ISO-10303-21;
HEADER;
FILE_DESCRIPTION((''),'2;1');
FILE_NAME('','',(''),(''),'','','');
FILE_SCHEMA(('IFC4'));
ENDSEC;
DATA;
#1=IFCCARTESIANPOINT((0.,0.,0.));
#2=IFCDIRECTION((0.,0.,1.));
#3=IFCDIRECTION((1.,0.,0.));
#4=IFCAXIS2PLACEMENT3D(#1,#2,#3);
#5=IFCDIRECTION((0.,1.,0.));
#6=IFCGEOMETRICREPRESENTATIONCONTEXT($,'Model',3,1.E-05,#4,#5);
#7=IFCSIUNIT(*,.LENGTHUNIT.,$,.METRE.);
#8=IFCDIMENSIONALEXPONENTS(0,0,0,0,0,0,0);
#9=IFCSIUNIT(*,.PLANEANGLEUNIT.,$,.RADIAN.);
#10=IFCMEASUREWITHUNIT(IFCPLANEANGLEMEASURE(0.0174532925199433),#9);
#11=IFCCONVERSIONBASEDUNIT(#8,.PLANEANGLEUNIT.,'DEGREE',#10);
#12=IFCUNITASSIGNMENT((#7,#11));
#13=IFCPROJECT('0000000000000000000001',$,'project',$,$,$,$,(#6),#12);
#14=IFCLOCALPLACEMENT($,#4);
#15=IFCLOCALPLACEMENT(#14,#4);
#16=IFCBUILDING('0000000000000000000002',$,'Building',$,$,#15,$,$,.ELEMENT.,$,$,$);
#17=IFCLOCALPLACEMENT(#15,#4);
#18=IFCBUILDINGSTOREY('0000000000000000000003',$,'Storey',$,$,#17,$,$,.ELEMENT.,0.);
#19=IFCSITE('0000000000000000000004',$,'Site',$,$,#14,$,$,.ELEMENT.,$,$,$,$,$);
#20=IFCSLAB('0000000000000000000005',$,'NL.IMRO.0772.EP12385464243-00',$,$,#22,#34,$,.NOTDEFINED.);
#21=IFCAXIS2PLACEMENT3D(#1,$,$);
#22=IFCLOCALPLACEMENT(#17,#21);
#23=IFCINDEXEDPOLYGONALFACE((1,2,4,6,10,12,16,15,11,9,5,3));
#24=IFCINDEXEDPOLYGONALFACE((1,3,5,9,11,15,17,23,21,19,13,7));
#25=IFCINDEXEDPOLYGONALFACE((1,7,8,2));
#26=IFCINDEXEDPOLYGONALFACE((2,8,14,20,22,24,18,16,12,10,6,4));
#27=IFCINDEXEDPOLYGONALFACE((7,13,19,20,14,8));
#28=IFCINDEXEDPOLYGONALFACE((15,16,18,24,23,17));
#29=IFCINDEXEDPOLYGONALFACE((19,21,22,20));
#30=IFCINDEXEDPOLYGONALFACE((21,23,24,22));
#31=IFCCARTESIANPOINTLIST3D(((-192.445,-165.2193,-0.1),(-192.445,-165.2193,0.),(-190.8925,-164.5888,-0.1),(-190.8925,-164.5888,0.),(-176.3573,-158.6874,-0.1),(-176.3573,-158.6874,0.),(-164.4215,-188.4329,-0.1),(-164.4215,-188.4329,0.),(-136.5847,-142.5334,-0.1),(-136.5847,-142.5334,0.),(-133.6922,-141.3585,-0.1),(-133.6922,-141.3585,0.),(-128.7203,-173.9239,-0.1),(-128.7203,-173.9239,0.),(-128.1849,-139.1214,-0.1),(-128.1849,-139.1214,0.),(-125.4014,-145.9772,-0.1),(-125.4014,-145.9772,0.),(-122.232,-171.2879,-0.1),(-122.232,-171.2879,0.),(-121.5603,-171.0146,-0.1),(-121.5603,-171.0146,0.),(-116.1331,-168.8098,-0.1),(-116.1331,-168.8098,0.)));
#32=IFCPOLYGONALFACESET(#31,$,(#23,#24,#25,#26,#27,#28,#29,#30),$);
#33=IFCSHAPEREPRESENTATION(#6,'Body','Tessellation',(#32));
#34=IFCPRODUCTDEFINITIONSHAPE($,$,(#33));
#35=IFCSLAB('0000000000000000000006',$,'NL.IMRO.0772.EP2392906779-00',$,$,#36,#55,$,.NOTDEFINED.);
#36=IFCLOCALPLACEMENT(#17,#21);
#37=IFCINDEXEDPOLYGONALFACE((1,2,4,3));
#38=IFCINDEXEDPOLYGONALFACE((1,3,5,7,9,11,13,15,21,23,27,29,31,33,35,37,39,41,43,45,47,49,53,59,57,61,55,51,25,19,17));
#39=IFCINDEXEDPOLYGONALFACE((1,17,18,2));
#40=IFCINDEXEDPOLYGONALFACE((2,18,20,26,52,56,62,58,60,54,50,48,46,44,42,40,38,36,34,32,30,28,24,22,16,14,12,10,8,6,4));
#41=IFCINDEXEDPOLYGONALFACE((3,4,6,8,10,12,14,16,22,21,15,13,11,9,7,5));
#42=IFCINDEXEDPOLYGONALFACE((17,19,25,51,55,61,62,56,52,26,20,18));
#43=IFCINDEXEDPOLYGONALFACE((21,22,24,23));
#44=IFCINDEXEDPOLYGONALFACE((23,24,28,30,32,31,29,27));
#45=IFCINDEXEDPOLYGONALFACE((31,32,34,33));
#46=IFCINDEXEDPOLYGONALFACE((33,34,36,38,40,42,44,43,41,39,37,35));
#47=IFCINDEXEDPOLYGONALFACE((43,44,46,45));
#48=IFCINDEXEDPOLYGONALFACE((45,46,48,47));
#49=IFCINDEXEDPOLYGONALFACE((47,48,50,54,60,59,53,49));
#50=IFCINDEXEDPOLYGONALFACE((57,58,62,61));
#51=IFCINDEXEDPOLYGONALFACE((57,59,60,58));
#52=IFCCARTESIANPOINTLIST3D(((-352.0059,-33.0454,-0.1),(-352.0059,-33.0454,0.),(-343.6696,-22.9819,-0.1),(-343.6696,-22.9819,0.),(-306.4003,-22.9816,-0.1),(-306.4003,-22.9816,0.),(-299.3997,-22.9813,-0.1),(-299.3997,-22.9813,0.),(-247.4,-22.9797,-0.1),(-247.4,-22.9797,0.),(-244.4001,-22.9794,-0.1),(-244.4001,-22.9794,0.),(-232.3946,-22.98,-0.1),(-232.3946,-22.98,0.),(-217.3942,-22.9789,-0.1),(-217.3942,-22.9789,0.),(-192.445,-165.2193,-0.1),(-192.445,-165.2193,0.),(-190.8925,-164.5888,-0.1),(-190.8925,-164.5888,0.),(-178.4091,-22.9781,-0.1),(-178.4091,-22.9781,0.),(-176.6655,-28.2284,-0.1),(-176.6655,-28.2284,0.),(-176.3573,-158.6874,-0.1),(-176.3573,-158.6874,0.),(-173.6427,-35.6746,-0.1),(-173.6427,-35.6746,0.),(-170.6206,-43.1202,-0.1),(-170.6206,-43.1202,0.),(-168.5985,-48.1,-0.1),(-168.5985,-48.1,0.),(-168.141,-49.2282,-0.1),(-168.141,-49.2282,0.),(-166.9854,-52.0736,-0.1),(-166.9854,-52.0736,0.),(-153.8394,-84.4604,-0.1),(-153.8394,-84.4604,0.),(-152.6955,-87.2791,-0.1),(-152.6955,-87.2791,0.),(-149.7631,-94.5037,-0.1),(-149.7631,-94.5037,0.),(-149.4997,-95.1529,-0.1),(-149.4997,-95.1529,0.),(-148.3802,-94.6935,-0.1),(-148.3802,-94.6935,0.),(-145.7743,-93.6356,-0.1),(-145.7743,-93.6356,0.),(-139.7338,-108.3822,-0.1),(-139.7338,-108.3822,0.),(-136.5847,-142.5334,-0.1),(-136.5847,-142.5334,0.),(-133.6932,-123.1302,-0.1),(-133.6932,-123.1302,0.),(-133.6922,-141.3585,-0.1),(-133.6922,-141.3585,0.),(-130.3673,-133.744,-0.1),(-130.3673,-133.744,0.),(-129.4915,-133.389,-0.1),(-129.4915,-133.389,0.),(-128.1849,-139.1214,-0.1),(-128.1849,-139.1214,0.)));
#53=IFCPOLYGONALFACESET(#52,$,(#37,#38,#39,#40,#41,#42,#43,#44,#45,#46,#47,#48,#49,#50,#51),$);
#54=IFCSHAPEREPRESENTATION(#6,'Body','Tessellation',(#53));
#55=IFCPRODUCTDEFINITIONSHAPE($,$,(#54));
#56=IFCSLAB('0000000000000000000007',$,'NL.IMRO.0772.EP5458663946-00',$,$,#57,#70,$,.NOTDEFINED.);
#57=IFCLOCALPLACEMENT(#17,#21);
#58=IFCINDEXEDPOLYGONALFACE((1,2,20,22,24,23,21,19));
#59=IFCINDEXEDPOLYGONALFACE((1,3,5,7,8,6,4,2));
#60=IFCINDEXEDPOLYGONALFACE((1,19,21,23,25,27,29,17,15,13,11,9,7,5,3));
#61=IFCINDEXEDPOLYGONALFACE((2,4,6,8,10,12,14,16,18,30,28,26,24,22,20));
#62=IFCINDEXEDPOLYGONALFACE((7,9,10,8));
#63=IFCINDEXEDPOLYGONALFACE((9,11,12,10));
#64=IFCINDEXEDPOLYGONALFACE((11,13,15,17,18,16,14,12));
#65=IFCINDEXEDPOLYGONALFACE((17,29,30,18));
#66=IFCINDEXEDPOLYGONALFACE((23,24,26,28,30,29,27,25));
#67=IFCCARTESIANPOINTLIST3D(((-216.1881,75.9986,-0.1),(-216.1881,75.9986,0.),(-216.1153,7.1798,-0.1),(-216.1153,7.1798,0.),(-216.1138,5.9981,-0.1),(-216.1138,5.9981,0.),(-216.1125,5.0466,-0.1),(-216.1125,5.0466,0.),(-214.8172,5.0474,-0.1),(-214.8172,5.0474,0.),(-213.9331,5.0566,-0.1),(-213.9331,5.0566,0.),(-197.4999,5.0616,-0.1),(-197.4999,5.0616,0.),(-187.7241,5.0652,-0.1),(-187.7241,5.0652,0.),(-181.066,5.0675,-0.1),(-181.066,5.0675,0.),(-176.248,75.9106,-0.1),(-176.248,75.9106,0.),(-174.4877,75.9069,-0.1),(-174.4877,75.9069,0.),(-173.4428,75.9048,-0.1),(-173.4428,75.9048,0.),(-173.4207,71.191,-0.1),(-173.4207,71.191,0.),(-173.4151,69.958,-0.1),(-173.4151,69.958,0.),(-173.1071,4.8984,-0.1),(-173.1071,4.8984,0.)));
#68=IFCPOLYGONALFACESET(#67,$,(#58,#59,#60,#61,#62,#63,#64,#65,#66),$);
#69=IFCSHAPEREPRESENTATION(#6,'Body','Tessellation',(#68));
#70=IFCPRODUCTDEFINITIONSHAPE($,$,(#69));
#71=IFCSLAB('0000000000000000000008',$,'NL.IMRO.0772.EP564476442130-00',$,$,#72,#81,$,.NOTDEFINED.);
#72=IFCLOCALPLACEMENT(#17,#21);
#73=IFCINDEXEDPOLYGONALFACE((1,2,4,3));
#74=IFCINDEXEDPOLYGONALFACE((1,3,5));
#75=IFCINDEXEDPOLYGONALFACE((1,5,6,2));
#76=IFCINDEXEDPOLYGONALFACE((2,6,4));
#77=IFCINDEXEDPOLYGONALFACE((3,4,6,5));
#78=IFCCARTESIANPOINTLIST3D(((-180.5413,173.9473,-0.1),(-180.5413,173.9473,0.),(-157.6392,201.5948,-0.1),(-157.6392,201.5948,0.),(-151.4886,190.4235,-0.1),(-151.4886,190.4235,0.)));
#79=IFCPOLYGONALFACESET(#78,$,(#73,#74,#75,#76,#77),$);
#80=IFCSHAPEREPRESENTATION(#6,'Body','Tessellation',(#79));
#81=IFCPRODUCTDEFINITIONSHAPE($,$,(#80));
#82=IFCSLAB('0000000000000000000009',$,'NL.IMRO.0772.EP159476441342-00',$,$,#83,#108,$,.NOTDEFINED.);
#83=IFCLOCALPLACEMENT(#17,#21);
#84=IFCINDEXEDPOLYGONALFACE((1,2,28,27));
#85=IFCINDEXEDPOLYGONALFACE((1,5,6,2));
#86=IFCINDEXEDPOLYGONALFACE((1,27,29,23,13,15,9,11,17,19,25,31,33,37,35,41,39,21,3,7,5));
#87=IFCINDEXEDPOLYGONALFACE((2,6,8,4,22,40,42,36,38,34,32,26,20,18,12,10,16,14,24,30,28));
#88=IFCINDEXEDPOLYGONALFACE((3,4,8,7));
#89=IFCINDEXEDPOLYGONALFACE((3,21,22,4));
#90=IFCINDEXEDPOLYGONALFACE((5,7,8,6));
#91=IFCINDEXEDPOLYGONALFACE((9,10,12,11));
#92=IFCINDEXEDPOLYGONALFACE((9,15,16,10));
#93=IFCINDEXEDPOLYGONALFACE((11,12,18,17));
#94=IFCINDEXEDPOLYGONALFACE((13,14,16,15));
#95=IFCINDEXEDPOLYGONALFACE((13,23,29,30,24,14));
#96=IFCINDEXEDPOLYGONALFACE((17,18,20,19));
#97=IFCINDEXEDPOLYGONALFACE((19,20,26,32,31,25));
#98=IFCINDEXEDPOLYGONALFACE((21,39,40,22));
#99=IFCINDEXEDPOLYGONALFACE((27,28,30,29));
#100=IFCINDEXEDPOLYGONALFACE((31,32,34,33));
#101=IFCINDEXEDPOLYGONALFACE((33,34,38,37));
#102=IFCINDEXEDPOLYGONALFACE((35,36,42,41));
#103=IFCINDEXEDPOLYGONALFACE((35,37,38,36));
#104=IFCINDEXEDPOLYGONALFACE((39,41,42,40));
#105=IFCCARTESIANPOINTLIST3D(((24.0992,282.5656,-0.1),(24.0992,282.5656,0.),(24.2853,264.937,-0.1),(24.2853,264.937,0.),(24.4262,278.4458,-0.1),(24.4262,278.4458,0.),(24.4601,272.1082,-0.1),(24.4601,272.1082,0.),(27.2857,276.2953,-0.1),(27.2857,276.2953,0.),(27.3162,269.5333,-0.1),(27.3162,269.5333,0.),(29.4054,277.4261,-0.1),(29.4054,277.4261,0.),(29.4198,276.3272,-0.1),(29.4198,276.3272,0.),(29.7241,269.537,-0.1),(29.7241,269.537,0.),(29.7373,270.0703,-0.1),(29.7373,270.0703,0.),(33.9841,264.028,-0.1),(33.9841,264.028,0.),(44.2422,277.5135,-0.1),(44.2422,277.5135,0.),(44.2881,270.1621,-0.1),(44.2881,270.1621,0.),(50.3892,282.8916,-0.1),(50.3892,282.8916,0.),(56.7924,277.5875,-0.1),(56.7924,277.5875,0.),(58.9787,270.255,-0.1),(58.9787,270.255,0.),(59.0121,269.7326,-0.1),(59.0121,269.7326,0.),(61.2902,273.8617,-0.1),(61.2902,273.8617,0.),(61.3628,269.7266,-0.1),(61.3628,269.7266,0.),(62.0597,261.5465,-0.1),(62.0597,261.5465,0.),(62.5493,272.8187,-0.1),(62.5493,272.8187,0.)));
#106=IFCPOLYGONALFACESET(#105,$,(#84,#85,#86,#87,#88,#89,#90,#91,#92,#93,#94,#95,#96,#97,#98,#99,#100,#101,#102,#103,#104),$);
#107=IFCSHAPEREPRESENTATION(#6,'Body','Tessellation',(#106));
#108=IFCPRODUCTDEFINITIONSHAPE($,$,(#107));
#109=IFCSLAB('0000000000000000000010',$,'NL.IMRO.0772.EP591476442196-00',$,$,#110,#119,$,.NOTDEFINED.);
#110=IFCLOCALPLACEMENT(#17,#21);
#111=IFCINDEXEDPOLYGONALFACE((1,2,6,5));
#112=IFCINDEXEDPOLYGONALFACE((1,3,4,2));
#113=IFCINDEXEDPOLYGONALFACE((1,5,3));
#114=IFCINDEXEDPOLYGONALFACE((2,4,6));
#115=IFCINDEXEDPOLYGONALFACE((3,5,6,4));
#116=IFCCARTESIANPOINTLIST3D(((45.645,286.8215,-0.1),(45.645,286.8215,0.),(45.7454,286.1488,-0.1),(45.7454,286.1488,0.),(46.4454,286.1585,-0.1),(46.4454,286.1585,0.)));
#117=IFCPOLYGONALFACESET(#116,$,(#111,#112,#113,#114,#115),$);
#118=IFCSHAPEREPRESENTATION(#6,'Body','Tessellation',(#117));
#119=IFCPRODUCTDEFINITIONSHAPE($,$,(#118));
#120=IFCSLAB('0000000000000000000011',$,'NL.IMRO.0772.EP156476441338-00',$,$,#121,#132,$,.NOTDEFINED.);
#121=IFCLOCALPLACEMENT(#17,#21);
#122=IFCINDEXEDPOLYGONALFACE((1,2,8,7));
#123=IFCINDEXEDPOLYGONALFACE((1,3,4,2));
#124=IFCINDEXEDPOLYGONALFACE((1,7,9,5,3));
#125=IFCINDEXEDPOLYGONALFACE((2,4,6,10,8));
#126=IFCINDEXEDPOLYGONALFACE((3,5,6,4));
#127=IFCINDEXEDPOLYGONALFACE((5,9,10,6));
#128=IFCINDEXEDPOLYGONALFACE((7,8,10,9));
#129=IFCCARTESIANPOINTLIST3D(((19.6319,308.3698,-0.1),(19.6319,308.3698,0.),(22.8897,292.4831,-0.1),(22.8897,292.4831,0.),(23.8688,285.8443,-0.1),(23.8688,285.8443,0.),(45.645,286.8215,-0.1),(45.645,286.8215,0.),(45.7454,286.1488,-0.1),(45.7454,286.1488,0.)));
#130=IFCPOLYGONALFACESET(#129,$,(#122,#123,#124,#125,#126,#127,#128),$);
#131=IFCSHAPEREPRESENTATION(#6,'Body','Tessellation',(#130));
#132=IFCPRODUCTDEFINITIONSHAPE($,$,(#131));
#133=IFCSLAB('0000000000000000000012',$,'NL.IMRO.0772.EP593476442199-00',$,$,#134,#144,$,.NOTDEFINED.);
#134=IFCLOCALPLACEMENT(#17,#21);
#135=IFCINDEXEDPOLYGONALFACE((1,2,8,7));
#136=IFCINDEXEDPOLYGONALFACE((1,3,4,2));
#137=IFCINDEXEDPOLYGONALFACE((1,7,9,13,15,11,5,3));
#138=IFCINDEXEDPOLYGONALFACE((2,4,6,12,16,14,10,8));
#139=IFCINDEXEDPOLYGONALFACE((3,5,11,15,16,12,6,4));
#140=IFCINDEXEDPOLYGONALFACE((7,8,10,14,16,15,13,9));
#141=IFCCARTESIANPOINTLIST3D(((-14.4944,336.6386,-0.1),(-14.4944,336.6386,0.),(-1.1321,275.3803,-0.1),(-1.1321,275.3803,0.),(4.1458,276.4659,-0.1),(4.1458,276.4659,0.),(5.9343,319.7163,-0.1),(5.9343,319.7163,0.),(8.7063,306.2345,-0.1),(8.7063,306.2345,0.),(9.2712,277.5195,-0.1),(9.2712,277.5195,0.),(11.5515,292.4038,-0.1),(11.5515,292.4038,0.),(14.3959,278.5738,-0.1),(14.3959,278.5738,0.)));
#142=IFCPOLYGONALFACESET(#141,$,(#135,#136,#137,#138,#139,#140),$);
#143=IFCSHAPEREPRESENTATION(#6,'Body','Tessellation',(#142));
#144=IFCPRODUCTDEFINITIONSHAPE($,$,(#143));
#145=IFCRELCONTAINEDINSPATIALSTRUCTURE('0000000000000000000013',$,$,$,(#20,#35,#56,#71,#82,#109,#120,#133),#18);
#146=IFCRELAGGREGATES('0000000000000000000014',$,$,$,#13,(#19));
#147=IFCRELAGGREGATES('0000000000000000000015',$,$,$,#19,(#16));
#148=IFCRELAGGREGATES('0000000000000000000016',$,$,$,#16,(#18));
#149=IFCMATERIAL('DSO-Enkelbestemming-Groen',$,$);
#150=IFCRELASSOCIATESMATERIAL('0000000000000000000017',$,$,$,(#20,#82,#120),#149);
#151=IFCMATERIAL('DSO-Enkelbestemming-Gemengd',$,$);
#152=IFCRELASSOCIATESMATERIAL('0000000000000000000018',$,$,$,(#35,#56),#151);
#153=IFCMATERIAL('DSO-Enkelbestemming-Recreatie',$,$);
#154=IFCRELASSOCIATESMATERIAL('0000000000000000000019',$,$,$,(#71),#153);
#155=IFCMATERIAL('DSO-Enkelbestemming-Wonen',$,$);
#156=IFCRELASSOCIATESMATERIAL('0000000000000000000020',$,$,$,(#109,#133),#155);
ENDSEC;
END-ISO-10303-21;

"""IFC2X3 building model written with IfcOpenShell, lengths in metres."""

from ifc_helpers import new_model, entity, si_unit, converted_unit, direction, frame, origin_with_axes, place, context, project, spatial, polyline, outline, extrude, material, element, save


model = new_model("IFC2X3")

# Units and contexts
model_context = context("Model", 3, precision=1e-05, world=origin_with_axes(), true_north=direction((0.0, 1.0, 0.0)))
ifc_project = project(units=[si_unit("LENGTHUNIT", "METRE"), converted_unit("PLANEANGLEUNIT", "DEGREE", entity("IfcPlaneAngleMeasure", 0.0174532925199433), si_unit("PLANEANGLEUNIT", "RADIAN"), dimensions=[0, 0, 0, 0, 0, 0, 0])], contexts=[model_context])

# Site, building, storey
site_placement = place(None, origin_with_axes())
site = spatial("IfcSite", under=ifc_project, at=site_placement, Name="Site", CompositionType="ELEMENT")
building_placement = place(site_placement, origin_with_axes())
building = spatial("IfcBuilding", under=site, at=building_placement, Name="Building", CompositionType="ELEMENT")
storey_placement = place(building_placement, origin_with_axes())
storey = spatial("IfcBuildingStorey", under=building, at=storey_placement, Name="Storey", CompositionType="ELEMENT", Elevation=0.0)

# Slabs
ifc_material_1 = material(Name="DSO-Enkelbestemming-Groen")
ifc_material_2 = material(Name="DSO-Enkelbestemming-Gemengd")
slab_1_placement = place(storey_placement, frame((0.0, 0.0, -0.1), z_axis=(0.0, 0.0, 1.0), x_axis=(1.0, 0.0, 0.0)))
element("IfcSlab", 1, at=slab_1_placement, inside=storey, material=ifc_material_1, Name="NL.IMRO.0772.EP12385464243-00", PredefinedType="NOTDEFINED", context=model_context, shape_type="SweptSolid", body=[
    extrude(outline(polyline([(-190.8925, -164.5888), (-176.3573, -158.6874), (-136.5847, -142.5334), (-133.6922, -141.3585), (-128.1849, -139.1214), (-125.4014, -145.9772), (-116.1331, -168.8098), (-121.5603, -171.0146), (-122.232, -171.2879), (-128.7203, -173.9239), (-164.4215, -188.4329), (-192.445, -165.2193), (-190.8925, -164.5888)])), origin_with_axes(), (0.0, 0.0, 1.0), 0.1),
])
slab_2_placement = place(storey_placement, frame((0.0, 0.0, -0.1), z_axis=(0.0, 0.0, 1.0), x_axis=(1.0, 0.0, 0.0)))
element("IfcSlab", 2, at=slab_2_placement, inside=storey, material=ifc_material_2, Name="NL.IMRO.0772.EP2392906779-00", PredefinedType="NOTDEFINED", context=model_context, shape_type="SweptSolid", body=[
    extrude(outline(polyline([(-306.4003, -22.9816), (-299.3997, -22.9813), (-247.4, -22.9797), (-244.4001, -22.9794), (-232.3946, -22.98), (-217.3942, -22.9789), (-178.4091, -22.9781), (-176.6655, -28.2284), (-173.6427, -35.6746), (-170.6206, -43.1202), (-168.5985, -48.1), (-168.141, -49.2282), (-166.9854, -52.0736), (-153.8394, -84.4604), (-152.6955, -87.2791), (-149.7631, -94.5037), (-149.4997, -95.1529), (-148.3802, -94.6935), (-145.7743, -93.6356), (-139.7338, -108.3822), (-133.6932, -123.1302), (-129.4915, -133.389), (-130.3673, -133.744), (-128.1849, -139.1214), (-133.6922, -141.3585), (-136.5847, -142.5334), (-176.3573, -158.6874), (-190.8925, -164.5888), (-192.445, -165.2193), (-352.0059, -33.0454), (-343.6696, -22.9819), (-306.4003, -22.9816)])), origin_with_axes(), (0.0, 0.0, 1.0), 0.1),
])
slab_3_placement = place(storey_placement, frame((0.0, 0.0, -0.1), z_axis=(0.0, 0.0, 1.0), x_axis=(1.0, 0.0, 0.0)))
element("IfcSlab", 3, at=slab_3_placement, inside=storey, material=ifc_material_2, Name="NL.IMRO.0772.EP5458663946-00", PredefinedType="NOTDEFINED", context=model_context, shape_type="SweptSolid", body=[
    extrude(outline(polyline([(-213.9331, 5.0566), (-214.8172, 5.0474), (-216.1125, 5.0466), (-216.1138, 5.9981), (-216.1153, 7.1798), (-216.1881, 75.9986), (-176.248, 75.9106), (-174.4877, 75.9069), (-173.4428, 75.9048), (-173.4207, 71.191), (-173.4151, 69.958), (-173.1071, 4.8984), (-181.066, 5.0675), (-187.7241, 5.0652), (-197.4999, 5.0616), (-213.9331, 5.0566)])), origin_with_axes(), (0.0, 0.0, 1.0), 0.1),
])
ifc_material_3 = material(Name="DSO-Enkelbestemming-Recreatie")
slab_4_placement = place(storey_placement, frame((0.0, 0.0, -0.1), z_axis=(0.0, 0.0, 1.0), x_axis=(1.0, 0.0, 0.0)))
element("IfcSlab", 4, at=slab_4_placement, inside=storey, material=ifc_material_3, Name="NL.IMRO.0772.EP564476442130-00", PredefinedType="NOTDEFINED", context=model_context, shape_type="SweptSolid", body=[
    extrude(outline(polyline([(-151.4886, 190.4235), (-180.5413, 173.9473), (-157.6392, 201.5948), (-151.4886, 190.4235)])), origin_with_axes(), (0.0, 0.0, 1.0), 0.1),
])
slab_5_placement = place(storey_placement, frame((0.0, 0.0, -0.1), z_axis=(0.0, 0.0, 1.0), x_axis=(1.0, 0.0, 0.0)))
element("IfcSlab", 5, at=slab_5_placement, inside=storey, material=ifc_material_1, Name="NL.IMRO.0772.EP159476441342-00", PredefinedType="NOTDEFINED", context=model_context, shape_type="SweptSolid", body=[
    extrude(outline(polyline([(62.0597, 261.5465), (33.9841, 264.028), (24.2853, 264.937), (24.4601, 272.1082), (24.4262, 278.4458), (24.0992, 282.5656), (50.3892, 282.8916), (56.7924, 277.5875), (44.2422, 277.5135), (29.4054, 277.4261), (29.4198, 276.3272), (27.2857, 276.2953), (27.3162, 269.5333), (29.7241, 269.537), (29.7373, 270.0703), (44.2881, 270.1621), (58.9787, 270.255), (59.0121, 269.7326), (61.3628, 269.7266), (61.2902, 273.8617), (62.5493, 272.8187), (62.0597, 261.5465)])), origin_with_axes(), (0.0, 0.0, 1.0), 0.1),
])
ifc_material_4 = material(Name="DSO-Enkelbestemming-Wonen")
slab_6_placement = place(storey_placement, frame((0.0, 0.0, -0.1), z_axis=(0.0, 0.0, 1.0), x_axis=(1.0, 0.0, 0.0)))
element("IfcSlab", 6, at=slab_6_placement, inside=storey, material=ifc_material_4, Name="NL.IMRO.0772.EP591476442196-00", PredefinedType="NOTDEFINED", context=model_context, shape_type="SweptSolid", body=[
    extrude(outline(polyline([(45.7454, 286.1488), (45.645, 286.8215), (46.4454, 286.1585), (45.7454, 286.1488)])), origin_with_axes(), (0.0, 0.0, 1.0), 0.1),
])
slab_7_placement = place(storey_placement, frame((0.0, 0.0, -0.1), z_axis=(0.0, 0.0, 1.0), x_axis=(1.0, 0.0, 0.0)))
element("IfcSlab", 7, at=slab_7_placement, inside=storey, material=ifc_material_1, Name="NL.IMRO.0772.EP156476441338-00", PredefinedType="NOTDEFINED", context=model_context, shape_type="SweptSolid", body=[
    extrude(outline(polyline([(45.7454, 286.1488), (23.8688, 285.8443), (22.8897, 292.4831), (19.6319, 308.3698), (45.645, 286.8215), (45.7454, 286.1488)])), origin_with_axes(), (0.0, 0.0, 1.0), 0.1),
])
slab_8_placement = place(storey_placement, frame((0.0, 0.0, -0.1), z_axis=(0.0, 0.0, 1.0), x_axis=(1.0, 0.0, 0.0)))
element("IfcSlab", 8, at=slab_8_placement, inside=storey, material=ifc_material_4, Name="NL.IMRO.0772.EP593476442199-00", PredefinedType="NOTDEFINED", context=model_context, shape_type="SweptSolid", body=[
    extrude(outline(polyline([(8.7063, 306.2345), (11.5515, 292.4038), (14.3959, 278.5738), (9.2712, 277.5195), (4.1458, 276.4659), (-1.1321, 275.3803), (-14.4944, 336.6386), (5.9343, 319.7163), (8.7063, 306.2345)])), origin_with_axes(), (0.0, 0.0, 1.0), 0.1),
])

save(model, "model.ifc")
